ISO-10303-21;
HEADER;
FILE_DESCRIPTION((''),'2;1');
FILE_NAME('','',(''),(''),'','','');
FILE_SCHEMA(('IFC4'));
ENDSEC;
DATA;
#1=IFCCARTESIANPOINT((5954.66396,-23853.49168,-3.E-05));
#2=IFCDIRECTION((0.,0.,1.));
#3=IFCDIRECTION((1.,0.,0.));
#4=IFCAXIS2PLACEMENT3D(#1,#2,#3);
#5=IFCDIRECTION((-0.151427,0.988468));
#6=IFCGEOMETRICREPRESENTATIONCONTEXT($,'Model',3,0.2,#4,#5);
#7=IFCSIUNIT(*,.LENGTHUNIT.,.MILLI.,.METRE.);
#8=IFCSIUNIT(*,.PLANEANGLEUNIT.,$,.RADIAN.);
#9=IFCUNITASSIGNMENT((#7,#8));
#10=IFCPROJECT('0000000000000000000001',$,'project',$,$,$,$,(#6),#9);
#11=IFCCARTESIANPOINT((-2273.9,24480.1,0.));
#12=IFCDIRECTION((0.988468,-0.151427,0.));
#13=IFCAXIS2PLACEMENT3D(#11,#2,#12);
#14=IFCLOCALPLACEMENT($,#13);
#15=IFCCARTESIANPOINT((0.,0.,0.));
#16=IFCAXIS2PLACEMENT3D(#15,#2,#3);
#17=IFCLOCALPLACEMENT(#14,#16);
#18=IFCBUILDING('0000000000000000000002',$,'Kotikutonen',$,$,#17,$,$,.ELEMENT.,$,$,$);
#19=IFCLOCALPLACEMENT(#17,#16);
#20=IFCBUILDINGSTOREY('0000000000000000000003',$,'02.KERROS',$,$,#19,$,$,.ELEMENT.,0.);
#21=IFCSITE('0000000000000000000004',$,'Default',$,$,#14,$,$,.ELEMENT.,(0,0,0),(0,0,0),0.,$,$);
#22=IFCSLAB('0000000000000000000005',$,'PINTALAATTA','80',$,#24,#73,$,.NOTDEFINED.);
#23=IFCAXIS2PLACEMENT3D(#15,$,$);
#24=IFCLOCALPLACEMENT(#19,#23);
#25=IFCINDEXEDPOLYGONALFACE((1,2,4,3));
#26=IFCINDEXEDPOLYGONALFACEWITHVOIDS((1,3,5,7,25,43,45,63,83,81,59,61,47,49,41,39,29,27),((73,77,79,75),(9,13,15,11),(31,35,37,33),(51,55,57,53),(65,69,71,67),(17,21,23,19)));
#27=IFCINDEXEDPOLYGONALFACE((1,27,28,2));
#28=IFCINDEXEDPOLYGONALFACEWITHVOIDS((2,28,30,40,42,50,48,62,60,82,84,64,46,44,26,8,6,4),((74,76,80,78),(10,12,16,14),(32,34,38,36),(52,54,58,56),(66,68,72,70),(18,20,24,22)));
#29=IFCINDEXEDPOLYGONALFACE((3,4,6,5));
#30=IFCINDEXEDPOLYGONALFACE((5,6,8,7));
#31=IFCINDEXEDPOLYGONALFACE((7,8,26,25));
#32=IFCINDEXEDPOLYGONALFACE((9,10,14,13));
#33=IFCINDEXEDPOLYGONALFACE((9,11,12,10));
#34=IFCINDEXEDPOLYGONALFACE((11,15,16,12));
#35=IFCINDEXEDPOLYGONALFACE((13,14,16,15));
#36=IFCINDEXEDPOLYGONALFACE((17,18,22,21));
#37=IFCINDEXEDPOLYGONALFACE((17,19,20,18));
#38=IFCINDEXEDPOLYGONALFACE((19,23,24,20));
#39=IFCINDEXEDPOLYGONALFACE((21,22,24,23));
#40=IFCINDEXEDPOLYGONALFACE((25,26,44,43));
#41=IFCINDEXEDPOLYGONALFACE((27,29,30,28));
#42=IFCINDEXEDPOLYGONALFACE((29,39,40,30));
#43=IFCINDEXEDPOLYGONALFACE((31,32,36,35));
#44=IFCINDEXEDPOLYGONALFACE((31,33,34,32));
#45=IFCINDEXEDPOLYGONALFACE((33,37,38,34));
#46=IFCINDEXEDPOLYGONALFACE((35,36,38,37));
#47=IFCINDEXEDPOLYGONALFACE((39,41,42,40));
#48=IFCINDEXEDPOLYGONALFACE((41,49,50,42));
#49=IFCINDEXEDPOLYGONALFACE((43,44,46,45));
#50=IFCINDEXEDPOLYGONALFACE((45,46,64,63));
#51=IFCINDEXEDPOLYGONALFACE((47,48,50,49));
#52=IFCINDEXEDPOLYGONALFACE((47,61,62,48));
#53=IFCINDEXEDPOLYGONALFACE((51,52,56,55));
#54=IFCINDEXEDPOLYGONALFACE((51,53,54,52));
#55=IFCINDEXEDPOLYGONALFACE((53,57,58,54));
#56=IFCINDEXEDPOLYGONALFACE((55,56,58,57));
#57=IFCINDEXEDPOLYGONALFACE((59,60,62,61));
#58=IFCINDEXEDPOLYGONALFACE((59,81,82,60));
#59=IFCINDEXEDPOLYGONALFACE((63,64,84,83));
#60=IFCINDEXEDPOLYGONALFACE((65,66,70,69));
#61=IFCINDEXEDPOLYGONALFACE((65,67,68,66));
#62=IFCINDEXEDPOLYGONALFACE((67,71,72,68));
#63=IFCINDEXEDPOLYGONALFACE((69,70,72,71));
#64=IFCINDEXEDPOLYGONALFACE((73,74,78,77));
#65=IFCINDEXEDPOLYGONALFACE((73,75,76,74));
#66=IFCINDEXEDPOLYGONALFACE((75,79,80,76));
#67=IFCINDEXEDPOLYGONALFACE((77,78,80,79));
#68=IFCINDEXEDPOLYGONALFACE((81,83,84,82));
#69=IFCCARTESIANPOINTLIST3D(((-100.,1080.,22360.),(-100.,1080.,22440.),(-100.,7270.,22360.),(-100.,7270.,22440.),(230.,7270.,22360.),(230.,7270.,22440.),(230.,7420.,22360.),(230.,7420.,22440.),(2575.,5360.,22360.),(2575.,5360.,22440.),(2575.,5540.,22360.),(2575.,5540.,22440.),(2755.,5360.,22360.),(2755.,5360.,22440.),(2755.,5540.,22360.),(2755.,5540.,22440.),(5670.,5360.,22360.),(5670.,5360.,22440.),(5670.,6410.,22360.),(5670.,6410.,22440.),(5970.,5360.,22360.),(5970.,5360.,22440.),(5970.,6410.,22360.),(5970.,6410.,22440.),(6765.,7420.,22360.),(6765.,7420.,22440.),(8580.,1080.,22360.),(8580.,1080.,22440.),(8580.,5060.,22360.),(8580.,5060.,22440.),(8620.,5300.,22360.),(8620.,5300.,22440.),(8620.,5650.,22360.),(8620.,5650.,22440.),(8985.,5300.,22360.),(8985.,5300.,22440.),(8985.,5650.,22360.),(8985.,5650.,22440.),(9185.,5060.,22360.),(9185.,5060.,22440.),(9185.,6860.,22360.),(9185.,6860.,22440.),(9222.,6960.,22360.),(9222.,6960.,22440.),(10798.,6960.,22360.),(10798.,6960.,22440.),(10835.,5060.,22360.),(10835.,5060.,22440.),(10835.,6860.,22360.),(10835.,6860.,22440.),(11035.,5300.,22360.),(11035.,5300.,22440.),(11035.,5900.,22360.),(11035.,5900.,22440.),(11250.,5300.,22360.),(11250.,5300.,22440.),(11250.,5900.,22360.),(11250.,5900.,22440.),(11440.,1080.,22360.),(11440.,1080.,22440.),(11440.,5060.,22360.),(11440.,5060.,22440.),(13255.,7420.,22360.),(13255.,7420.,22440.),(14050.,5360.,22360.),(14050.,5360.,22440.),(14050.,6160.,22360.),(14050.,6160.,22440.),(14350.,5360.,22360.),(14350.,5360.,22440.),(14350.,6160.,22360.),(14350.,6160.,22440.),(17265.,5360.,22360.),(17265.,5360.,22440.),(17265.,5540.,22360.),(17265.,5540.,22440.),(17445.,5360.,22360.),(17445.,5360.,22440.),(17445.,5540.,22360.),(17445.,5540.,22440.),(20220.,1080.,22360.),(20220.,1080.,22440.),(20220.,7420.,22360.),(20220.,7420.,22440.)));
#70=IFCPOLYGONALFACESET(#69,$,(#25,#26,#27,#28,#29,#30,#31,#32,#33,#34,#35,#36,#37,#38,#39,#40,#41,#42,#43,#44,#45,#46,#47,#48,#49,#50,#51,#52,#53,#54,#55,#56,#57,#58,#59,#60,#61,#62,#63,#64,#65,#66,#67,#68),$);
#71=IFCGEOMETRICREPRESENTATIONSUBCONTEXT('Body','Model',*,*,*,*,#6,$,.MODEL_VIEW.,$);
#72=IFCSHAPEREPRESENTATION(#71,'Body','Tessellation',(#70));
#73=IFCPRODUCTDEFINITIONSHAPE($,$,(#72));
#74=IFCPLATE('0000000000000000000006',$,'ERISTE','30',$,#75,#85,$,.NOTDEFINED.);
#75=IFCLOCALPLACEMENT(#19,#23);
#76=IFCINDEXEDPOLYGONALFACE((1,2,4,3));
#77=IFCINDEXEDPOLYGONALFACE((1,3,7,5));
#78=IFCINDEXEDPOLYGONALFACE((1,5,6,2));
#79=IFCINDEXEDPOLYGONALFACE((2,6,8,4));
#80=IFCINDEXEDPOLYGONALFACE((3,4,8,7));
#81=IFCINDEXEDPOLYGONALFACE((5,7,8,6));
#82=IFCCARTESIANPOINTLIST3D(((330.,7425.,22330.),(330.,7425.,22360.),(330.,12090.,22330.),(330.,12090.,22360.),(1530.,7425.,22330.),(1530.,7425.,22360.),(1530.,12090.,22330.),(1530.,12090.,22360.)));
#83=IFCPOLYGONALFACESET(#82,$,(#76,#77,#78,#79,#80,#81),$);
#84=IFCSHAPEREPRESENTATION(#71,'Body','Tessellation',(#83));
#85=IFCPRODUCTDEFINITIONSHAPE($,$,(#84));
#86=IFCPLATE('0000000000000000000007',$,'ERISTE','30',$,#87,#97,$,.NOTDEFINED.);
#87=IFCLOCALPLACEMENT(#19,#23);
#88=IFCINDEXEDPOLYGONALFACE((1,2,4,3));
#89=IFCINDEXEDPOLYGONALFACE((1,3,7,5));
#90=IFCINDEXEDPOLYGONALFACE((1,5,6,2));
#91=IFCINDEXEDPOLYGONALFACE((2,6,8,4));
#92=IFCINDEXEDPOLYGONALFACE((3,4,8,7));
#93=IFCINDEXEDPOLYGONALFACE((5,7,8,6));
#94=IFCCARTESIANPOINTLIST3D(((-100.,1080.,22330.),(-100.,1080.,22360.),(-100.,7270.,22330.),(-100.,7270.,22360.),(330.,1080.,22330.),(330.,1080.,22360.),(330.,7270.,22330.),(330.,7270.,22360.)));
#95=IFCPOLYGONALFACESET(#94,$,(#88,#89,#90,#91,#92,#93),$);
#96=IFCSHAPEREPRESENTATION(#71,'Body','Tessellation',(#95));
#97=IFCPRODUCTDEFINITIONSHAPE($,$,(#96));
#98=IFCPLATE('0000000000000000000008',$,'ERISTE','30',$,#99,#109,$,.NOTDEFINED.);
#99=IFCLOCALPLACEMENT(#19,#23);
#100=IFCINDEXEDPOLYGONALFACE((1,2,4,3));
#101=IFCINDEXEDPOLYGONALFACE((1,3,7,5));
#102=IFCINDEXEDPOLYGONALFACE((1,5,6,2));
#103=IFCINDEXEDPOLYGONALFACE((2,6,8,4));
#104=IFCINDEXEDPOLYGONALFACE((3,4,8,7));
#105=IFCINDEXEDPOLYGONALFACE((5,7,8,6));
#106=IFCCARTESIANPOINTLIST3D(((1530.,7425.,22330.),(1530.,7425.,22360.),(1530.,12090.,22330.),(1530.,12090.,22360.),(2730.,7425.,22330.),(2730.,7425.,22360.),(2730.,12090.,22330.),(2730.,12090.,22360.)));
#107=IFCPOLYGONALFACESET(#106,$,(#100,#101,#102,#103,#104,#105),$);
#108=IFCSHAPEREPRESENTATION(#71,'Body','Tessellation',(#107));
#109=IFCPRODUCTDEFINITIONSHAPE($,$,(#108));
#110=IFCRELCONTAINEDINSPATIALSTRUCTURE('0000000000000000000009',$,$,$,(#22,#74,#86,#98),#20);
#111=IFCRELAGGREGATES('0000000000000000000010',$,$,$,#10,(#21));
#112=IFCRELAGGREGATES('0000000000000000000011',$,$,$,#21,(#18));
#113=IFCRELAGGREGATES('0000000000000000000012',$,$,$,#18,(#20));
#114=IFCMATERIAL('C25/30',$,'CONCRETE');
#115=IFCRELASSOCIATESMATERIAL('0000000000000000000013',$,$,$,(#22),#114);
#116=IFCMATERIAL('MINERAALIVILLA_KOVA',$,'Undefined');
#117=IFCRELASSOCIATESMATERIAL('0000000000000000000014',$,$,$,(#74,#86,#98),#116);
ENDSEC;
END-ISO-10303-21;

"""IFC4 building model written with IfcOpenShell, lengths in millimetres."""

from ifc_helpers import new_model, si_unit, direction, frame, origin_with_axes, place, context, subcontext, project, spatial, line, indexed_curve, outline, extrude, material, element, save


model = new_model("IFC4")

# Units and contexts
model_context = context("Model", 3, precision=0.2, world=frame((5954.66396, -23853.49168, -3e-05), z_axis=(0.0, 0.0, 1.0), x_axis=(1.0, 0.0, 0.0)), true_north=direction((-0.151427, 0.988468)))
body_context = subcontext(model_context, "Body", "Model", "MODEL_VIEW")
ifc_project = project(units=[si_unit("LENGTHUNIT", "METRE", prefix="MILLI"), si_unit("PLANEANGLEUNIT", "RADIAN")], contexts=[model_context])

# Site, building, storey
site_placement = place(None, frame((-2273.9, 24480.1, 0.0), z_axis=(0.0, 0.0, 1.0), x_axis=(0.988468, -0.151427, 0.0)))
site = spatial("IfcSite", under=ifc_project, at=site_placement, Name="Default", CompositionType="ELEMENT", RefLatitude=(0, 0, 0), RefLongitude=(0, 0, 0), RefElevation=0.0)
building_placement = place(site_placement, origin_with_axes())
building = spatial("IfcBuilding", under=site, at=building_placement, Name="Kotikutonen", CompositionType="ELEMENT")
storey_placement = place(building_placement, origin_with_axes())
storey = spatial("IfcBuildingStorey", under=building, at=storey_placement, Name="02.KERROS", CompositionType="ELEMENT", Elevation=0.0)

# Slab, voiding features
ifc_material_1 = material(Name="C25/30", Category="CONCRETE")
slab_1_placement = place(storey_placement, frame((-100.0, 7270.0, 22400.0), z_axis=(0.0, 0.0, 1.0), x_axis=(0.0, -1.0, 0.0)))
slab_1 = element("IfcSlab", 1, at=slab_1_placement, inside=storey, material=ifc_material_1, Name="PINTALAATTA", Description="80", PredefinedType="NOTDEFINED", context=body_context, shape_type="SolidModel", body=[
    extrude(outline(indexed_curve([(0.0, 0.0), (6190.0, 0.0), (6190.0, 8680.0), (7270.0, 8680.0), (7270.0, 11540.0), (6190.0, 11540.0), (6190.0, 20320.0), (-150.0, 20320.0), (-150.0, 13355.0), (310.0, 10898.0), (310.0, 9322.0), (-150.0, 6865.0), (-150.0, 330.0), (0.0, 330.0)], segments=[line(1, 2, 3, 4, 5, 6, 7, 8, 9, 10, 11, 12, 13, 14, 1)])), frame((0.0, 0.0, 40.0), z_axis=(0.0, 0.0, 1.0), x_axis=(1.0, 0.0, 0.0)), (0.0, 0.0, -1.0), 80.0),
])
voiding_feature_1_placement = place(slab_1_placement, frame((2210.0, 8680.0, 0.0), z_axis=(0.0, 0.0, 1.0), x_axis=(1.0, 0.0, 0.0)))
element("IfcVoidingFeature", 2, at=voiding_feature_1_placement, cuts=slab_1, Name="POLYGON CUT", PredefinedType="HOLE", context=body_context, shape_type="SolidModel", body=[
    extrude(outline(indexed_curve([(0.0, 0.0), (5060.0, 0.0), (5060.0, 2860.0), (0.0, 2860.0), (0.0, 2255.0), (-1800.0, 2255.0), (-1800.0, 605.0), (0.0, 605.0)], segments=[line(1, 2, 3, 4, 5, 6, 7, 8, 1)])), frame((0.0, 0.0, 115.0), z_axis=(0.0, 0.0, 1.0), x_axis=(1.0, 0.0, 0.0)), (0.0, 0.0, -1.0), 230.0),
])
voiding_feature_2_placement = place(slab_1_placement, frame((1620.0, 8720.0, 0.0), z_axis=(0.0, 0.0, 1.0), x_axis=(1.0, 0.0, 0.0)))
element("IfcVoidingFeature", 3, at=voiding_feature_2_placement, cuts=slab_1, Name="POLYGON CUT", PredefinedType="HOLE", context=body_context, shape_type="SolidModel", body=[
    extrude(outline(indexed_curve([(0.0, 0.0), (350.0, 0.0), (350.0, 365.0), (0.0, 365.0)], segments=[line(1, 2, 3, 4, 1)])), frame((0.0, 0.0, 115.0), z_axis=(0.0, 0.0, 1.0), x_axis=(1.0, 0.0, 0.0)), (0.0, 0.0, -1.0), 230.0),
])
voiding_feature_3_placement = place(slab_1_placement, frame((1370.0, 11135.0, 0.0), z_axis=(0.0, 0.0, 1.0), x_axis=(1.0, 0.0, 0.0)))
element("IfcVoidingFeature", 4, at=voiding_feature_3_placement, cuts=slab_1, Name="POLYGON CUT", PredefinedType="HOLE", context=body_context, shape_type="SolidModel", body=[
    extrude(outline(indexed_curve([(0.0, 0.0), (600.0, 0.0), (600.0, 215.0), (0.0, 215.0)], segments=[line(1, 2, 3, 4, 1)])), frame((0.0, 0.0, 115.0), z_axis=(0.0, 0.0, 1.0), x_axis=(1.0, 0.0, 0.0)), (0.0, 0.0, -1.0), 230.0),
])
voiding_feature_4_placement = place(slab_1_placement, frame((860.0, 5770.0, 0.0), z_axis=(0.0, 0.0, 1.0), x_axis=(1.0, 0.0, 0.0)))
element("IfcVoidingFeature", 5, at=voiding_feature_4_placement, cuts=slab_1, Name="POLYGON CUT", PredefinedType="HOLE", context=body_context, shape_type="SolidModel", body=[
    extrude(outline(indexed_curve([(0.0, 0.0), (1050.0, 0.0), (1050.0, 300.0), (0.0, 300.0)], segments=[line(1, 2, 3, 4, 1)])), frame((0.0, 0.0, 115.0), z_axis=(0.0, 0.0, 1.0), x_axis=(1.0, 0.0, 0.0)), (0.0, 0.0, -1.0), 230.0),
])
voiding_feature_5_placement = place(slab_1_placement, frame((1110.0, 14150.0, 0.0), z_axis=(0.0, 0.0, 1.0), x_axis=(1.0, 0.0, 0.0)))
element("IfcVoidingFeature", 6, at=voiding_feature_5_placement, cuts=slab_1, Name="POLYGON CUT", PredefinedType="HOLE", context=body_context, shape_type="SolidModel", body=[
    extrude(outline(indexed_curve([(0.0, 0.0), (800.0, 0.0), (800.0, 300.0), (0.0, 300.0)], segments=[line(1, 2, 3, 4, 1)])), frame((0.0, 0.0, 115.0), z_axis=(0.0, 0.0, 1.0), x_axis=(1.0, 0.0, 0.0)), (0.0, 0.0, -1.0), 230.0),
])
voiding_feature_6_placement = place(slab_1_placement, frame((1730.0, 2675.0, 0.0), z_axis=(0.0, 0.0, 1.0), x_axis=(1.0, 0.0, 0.0)))
element("IfcVoidingFeature", 7, at=voiding_feature_6_placement, cuts=slab_1, Name="POLYGON CUT", PredefinedType="HOLE", context=body_context, shape_type="SolidModel", body=[
    extrude(outline(indexed_curve([(0.0, 0.0), (180.0, 0.0), (180.0, 180.0), (0.0, 180.0)], segments=[line(1, 2, 3, 4, 1)])), frame((0.0, 0.0, 115.0), z_axis=(0.0, 0.0, 1.0), x_axis=(1.0, 0.0, 0.0)), (0.0, 0.0, -1.0), 230.0),
])
voiding_feature_7_placement = place(slab_1_placement, frame((1730.0, 17365.0, 0.0), z_axis=(0.0, 0.0, 1.0), x_axis=(1.0, 0.0, 0.0)))
element("IfcVoidingFeature", 8, at=voiding_feature_7_placement, cuts=slab_1, Name="POLYGON CUT", PredefinedType="HOLE", context=body_context, shape_type="SolidModel", body=[
    extrude(outline(indexed_curve([(0.0, 0.0), (180.0, 0.0), (180.0, 180.0), (0.0, 180.0)], segments=[line(1, 2, 3, 4, 1)])), frame((0.0, 0.0, 115.0), z_axis=(0.0, 0.0, 1.0), x_axis=(1.0, 0.0, 0.0)), (0.0, 0.0, -1.0), 230.0),
])

# Plates
ifc_material_2 = material(Name="MINERAALIVILLA_KOVA", Category="Undefined")
plate_1_placement = place(storey_placement, frame((330.0, 7425.0, 22345.0), z_axis=(0.0, 0.0, 1.0), x_axis=(1.0, 0.0, 0.0)))
element("IfcPlate", 9, at=plate_1_placement, inside=storey, material=ifc_material_2, Name="ERISTE", Description="30", PredefinedType="NOTDEFINED", context=body_context, shape_type="SolidModel", body=[
    extrude(outline(indexed_curve([(0.0, 0.0), (1200.0, 0.0), (1200.0, 4665.0), (0.0, 4665.0)], segments=[line(1, 2, 3, 4, 1)])), frame((0.0, 0.0, 15.0), z_axis=(0.0, 0.0, 1.0), x_axis=(1.0, 0.0, 0.0)), (0.0, 0.0, -1.0), 30.0),
])
plate_2_placement = place(storey_placement, frame((-100.0, 7270.0, 22345.0), z_axis=(0.0, 0.0, 1.0), x_axis=(0.0, -1.0, 0.0)))
element("IfcPlate", 10, at=plate_2_placement, inside=storey, material=ifc_material_2, Name="ERISTE", Description="30", PredefinedType="NOTDEFINED", context=body_context, shape_type="SolidModel", body=[
    extrude(outline(indexed_curve([(0.0, 0.0), (6190.0, 0.0), (6190.0, 430.0), (0.0, 430.0)], segments=[line(1, 2, 3, 4, 1)])), frame((0.0, 0.0, 15.0), z_axis=(0.0, 0.0, 1.0), x_axis=(1.0, 0.0, 0.0)), (0.0, 0.0, -1.0), 30.0),
])
plate_3_placement = place(storey_placement, frame((1530.0, 7425.0, 22345.0), z_axis=(0.0, 0.0, 1.0), x_axis=(1.0, 0.0, 0.0)))
element("IfcPlate", 11, at=plate_3_placement, inside=storey, material=ifc_material_2, Name="ERISTE", Description="30", PredefinedType="NOTDEFINED", context=body_context, shape_type="SolidModel", body=[
    extrude(outline(indexed_curve([(0.0, 0.0), (1200.0, 0.0), (1200.0, 4665.0), (0.0, 4665.0)], segments=[line(1, 2, 3, 4, 1)])), frame((0.0, 0.0, 15.0), z_axis=(0.0, 0.0, 1.0), x_axis=(1.0, 0.0, 0.0)), (0.0, 0.0, -1.0), 30.0),
])

save(model, "model.ifc")
